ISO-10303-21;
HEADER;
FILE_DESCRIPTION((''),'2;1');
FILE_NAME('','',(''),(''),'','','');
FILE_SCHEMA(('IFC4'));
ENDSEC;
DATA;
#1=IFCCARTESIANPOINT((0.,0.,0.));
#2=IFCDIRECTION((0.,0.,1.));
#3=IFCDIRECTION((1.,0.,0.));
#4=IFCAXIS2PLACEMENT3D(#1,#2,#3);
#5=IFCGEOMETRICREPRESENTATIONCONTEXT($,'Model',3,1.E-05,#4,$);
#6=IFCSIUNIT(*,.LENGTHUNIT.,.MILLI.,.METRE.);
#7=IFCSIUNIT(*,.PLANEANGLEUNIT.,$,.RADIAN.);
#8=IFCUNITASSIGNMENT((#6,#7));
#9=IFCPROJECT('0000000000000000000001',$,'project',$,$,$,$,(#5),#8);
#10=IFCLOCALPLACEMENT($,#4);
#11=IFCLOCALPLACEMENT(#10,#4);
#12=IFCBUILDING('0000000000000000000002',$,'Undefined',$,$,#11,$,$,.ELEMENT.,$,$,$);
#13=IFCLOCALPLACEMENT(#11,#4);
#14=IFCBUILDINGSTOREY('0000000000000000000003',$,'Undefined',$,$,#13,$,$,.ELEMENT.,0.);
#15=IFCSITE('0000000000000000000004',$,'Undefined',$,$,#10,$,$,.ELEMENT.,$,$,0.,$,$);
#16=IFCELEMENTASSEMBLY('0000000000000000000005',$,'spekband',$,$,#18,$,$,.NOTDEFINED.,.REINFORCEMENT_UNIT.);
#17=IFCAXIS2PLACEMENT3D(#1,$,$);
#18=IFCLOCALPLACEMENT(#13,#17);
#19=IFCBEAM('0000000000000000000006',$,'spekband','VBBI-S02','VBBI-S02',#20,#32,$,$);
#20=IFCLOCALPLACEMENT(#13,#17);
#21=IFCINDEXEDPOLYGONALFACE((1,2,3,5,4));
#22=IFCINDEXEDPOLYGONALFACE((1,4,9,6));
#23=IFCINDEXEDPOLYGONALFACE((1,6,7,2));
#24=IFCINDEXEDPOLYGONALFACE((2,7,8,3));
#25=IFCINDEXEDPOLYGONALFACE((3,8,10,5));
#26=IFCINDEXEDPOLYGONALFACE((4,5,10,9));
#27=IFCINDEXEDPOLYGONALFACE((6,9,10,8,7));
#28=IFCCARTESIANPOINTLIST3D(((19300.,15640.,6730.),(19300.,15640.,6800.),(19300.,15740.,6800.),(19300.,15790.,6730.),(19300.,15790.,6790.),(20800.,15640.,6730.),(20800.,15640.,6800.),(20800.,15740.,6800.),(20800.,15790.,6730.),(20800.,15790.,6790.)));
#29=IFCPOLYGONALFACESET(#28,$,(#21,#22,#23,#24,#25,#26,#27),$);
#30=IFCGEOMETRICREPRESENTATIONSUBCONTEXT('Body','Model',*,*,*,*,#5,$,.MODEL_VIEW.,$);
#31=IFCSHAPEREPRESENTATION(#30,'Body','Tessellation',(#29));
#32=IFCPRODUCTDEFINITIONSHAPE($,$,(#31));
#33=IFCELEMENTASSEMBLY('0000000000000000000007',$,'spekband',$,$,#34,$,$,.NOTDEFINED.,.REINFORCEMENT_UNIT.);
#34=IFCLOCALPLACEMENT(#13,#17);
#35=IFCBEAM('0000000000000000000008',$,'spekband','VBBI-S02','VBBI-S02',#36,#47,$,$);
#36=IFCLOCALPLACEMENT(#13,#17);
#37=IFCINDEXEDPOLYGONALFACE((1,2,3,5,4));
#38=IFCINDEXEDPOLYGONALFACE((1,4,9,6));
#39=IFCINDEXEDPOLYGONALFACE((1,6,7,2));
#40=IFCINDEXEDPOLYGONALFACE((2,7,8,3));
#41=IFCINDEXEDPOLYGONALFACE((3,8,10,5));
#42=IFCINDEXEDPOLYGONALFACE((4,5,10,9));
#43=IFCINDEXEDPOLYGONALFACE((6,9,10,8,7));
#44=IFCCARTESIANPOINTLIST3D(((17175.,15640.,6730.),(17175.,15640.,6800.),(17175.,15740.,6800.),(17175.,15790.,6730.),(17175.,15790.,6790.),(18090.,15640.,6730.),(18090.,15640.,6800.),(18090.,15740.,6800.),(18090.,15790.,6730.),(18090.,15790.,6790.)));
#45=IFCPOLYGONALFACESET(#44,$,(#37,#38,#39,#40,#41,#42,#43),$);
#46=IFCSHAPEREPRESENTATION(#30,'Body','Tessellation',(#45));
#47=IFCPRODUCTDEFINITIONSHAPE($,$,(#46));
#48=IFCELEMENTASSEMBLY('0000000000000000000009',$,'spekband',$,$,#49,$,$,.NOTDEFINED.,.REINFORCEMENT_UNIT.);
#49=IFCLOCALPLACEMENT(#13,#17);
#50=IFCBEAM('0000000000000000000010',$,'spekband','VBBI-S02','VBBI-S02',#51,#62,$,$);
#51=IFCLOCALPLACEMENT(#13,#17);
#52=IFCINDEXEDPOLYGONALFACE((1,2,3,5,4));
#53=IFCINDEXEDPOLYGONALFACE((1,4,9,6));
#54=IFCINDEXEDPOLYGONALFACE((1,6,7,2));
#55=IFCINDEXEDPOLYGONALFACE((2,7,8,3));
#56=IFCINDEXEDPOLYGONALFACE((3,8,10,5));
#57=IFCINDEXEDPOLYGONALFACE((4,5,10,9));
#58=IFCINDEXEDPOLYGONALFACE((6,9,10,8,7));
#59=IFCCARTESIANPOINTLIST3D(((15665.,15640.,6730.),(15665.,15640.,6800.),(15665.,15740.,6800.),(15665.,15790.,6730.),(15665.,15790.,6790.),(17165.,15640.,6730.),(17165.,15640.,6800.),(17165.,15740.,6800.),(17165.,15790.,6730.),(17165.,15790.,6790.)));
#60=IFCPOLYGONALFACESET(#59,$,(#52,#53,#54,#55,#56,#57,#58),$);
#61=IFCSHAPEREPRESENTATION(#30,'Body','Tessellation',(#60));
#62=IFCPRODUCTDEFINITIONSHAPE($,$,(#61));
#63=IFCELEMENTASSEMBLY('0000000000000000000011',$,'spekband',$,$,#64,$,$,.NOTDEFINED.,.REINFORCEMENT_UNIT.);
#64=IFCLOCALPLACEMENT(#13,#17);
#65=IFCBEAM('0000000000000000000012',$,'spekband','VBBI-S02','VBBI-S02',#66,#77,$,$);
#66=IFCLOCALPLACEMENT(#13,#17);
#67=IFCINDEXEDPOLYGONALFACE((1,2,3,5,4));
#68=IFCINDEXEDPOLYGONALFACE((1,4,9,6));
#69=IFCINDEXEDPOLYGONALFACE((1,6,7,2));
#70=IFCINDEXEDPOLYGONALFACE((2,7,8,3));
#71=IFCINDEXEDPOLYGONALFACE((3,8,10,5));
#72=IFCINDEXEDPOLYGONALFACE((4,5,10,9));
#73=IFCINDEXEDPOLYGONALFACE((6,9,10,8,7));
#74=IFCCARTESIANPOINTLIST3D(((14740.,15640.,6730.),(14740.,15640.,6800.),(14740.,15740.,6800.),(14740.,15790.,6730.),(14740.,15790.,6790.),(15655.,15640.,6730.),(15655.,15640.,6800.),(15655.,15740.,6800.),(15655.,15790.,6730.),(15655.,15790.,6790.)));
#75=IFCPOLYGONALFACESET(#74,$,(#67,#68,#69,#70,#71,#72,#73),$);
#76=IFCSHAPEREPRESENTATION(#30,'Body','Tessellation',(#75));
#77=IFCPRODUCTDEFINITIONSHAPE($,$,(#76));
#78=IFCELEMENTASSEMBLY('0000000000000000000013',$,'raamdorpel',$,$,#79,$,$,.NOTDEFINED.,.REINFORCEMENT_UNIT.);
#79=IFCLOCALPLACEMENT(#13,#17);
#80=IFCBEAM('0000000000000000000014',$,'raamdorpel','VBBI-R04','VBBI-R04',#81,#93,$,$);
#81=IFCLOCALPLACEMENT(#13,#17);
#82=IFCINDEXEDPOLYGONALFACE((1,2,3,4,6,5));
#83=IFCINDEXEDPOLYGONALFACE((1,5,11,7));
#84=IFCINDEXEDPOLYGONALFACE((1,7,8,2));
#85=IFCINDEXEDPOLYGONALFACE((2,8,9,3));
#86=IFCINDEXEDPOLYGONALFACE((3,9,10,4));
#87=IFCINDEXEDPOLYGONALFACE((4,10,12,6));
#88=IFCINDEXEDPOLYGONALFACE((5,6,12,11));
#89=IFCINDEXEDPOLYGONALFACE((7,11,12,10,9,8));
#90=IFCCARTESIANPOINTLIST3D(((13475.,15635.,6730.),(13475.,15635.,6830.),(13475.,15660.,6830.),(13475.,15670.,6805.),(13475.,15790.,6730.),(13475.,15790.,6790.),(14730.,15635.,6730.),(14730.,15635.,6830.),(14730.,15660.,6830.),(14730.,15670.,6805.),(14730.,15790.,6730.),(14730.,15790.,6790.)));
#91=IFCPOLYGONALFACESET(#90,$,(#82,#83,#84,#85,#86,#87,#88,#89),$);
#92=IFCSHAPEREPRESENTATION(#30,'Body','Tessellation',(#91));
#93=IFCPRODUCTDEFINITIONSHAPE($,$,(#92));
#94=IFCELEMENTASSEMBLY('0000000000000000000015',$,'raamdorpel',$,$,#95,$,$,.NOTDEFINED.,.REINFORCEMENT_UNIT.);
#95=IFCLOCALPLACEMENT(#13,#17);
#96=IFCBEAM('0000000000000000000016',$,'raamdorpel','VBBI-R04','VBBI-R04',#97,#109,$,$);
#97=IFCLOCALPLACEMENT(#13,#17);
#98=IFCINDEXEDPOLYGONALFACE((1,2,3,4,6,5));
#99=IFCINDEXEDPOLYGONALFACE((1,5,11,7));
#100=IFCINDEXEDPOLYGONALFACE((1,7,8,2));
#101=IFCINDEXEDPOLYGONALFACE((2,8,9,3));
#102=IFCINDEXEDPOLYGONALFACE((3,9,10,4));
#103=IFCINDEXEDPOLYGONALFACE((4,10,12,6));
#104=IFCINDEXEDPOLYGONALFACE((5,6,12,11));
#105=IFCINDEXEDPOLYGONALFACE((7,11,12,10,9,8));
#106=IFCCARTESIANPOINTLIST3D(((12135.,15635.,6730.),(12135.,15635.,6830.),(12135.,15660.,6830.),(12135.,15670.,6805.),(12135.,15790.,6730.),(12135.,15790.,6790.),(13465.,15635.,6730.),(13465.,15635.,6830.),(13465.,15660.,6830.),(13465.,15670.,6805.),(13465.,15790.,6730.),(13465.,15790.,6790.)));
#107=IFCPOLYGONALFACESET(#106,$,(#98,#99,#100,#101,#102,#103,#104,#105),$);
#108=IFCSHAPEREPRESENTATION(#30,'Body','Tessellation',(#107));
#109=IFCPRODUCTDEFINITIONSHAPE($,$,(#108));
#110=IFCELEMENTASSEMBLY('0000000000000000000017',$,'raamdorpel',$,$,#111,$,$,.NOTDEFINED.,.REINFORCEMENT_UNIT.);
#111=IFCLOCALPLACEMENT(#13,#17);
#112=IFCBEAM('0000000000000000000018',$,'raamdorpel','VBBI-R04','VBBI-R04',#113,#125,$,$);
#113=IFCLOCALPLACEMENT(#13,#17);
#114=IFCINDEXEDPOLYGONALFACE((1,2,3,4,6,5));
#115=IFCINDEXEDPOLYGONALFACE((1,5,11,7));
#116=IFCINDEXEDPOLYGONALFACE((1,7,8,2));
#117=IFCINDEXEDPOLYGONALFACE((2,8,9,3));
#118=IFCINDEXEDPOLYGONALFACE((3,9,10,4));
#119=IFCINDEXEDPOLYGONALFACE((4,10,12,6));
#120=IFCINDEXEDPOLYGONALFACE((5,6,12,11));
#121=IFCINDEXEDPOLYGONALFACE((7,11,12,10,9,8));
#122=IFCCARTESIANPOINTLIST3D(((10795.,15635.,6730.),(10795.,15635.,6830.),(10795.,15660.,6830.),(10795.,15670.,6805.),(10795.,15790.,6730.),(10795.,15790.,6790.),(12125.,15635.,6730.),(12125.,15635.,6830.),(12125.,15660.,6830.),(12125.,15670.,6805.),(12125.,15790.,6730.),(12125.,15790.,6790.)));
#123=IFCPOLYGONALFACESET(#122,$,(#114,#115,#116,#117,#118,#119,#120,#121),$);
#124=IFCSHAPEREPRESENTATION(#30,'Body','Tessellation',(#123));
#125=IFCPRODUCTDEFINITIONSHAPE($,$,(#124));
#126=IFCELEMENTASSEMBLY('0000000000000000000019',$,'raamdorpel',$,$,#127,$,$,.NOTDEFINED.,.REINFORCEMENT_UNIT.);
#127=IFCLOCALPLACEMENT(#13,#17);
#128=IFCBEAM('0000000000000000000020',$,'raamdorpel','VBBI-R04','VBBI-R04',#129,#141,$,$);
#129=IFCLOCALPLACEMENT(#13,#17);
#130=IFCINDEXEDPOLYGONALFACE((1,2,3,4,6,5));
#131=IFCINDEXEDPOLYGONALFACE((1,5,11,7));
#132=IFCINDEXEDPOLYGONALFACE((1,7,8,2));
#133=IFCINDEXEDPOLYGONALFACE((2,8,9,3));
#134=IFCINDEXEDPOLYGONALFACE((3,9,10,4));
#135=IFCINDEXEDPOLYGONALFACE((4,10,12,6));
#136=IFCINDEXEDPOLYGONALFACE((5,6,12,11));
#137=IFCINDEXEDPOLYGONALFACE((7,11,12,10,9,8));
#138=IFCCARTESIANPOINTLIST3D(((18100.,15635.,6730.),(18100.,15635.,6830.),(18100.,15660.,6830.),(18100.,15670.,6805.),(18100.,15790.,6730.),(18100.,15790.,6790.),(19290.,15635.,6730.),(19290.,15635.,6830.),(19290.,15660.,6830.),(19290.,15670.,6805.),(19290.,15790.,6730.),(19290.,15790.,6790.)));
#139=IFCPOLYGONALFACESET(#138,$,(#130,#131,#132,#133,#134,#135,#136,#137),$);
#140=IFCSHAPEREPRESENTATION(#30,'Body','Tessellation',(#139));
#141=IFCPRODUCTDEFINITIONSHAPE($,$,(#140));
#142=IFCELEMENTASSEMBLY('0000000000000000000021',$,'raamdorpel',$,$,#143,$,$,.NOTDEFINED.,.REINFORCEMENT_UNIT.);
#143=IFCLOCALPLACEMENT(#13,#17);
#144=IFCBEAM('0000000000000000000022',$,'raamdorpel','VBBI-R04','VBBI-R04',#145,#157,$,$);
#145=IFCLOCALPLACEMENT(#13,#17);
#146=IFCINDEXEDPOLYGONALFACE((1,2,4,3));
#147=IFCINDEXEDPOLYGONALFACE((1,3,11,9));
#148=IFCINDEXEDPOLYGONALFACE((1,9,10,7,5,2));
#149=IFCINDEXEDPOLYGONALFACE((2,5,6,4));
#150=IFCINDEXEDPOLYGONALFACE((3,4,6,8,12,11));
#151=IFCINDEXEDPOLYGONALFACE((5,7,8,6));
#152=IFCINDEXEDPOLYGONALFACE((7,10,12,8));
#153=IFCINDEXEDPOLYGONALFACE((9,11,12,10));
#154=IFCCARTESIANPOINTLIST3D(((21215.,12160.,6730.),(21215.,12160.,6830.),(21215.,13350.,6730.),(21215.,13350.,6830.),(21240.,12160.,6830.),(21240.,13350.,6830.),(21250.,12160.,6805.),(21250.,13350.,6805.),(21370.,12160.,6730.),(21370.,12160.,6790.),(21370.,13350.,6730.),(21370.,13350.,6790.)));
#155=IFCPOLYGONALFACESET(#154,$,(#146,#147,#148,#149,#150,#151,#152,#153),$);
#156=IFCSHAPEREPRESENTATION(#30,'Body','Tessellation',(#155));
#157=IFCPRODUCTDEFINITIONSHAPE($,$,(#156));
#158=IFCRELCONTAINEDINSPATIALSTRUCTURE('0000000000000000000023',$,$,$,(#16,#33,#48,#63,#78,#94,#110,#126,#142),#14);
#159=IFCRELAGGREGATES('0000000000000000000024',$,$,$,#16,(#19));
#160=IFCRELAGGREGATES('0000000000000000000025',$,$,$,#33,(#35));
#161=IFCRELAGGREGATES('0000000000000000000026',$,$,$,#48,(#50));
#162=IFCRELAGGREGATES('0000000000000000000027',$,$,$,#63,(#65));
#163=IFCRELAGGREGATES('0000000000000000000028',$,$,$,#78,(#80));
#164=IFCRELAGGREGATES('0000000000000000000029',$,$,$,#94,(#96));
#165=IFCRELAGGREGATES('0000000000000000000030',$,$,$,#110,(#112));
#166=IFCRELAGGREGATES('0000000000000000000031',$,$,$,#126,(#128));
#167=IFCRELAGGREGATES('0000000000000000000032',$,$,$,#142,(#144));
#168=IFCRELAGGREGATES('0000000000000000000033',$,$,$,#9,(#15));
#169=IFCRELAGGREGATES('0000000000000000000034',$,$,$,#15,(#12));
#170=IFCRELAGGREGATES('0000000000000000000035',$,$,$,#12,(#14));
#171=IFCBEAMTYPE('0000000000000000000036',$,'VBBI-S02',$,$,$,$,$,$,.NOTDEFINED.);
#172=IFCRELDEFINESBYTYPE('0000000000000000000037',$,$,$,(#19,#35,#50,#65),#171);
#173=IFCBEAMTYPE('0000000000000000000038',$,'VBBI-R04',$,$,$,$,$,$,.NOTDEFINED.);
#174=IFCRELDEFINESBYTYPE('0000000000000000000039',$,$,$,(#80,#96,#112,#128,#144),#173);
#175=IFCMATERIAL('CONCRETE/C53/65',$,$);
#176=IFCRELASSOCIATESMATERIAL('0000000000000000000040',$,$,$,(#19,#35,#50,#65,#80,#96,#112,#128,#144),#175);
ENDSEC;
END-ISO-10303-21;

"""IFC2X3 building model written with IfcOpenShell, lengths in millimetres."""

from ifc_helpers import new_model, si_unit, frame, origin_with_axes, place, context, subcontext, project, spatial, polyline, outline, extrude, material, type_object, element, aggregate, save


model = new_model("IFC2X3")

# Units and contexts
model_context = context("Model", 3, precision=1e-05, world=origin_with_axes())
body_context = subcontext(model_context, "Body", "Model", "MODEL_VIEW")
ifc_project = project(units=[si_unit("LENGTHUNIT", "METRE", prefix="MILLI"), si_unit("PLANEANGLEUNIT", "RADIAN")], contexts=[model_context])

# Site, building, storey
site_placement = place(None, origin_with_axes())
site = spatial("IfcSite", under=ifc_project, at=site_placement, Name="Undefined", CompositionType="ELEMENT", RefElevation=0.0)
building_placement = place(site_placement, origin_with_axes())
building = spatial("IfcBuilding", under=site, at=building_placement, Name="Undefined", CompositionType="ELEMENT")
storey_placement = place(building_placement, origin_with_axes())
storey = spatial("IfcBuildingStorey", under=building, at=storey_placement, Name="Undefined", CompositionType="ELEMENT", Elevation=0.0)

# Element assemblies, beams
ifc_material = material(Name="CONCRETE/C53/65")
beam_type_1 = type_object("IfcBeamType", Name="VBBI-S02", PredefinedType="NOTDEFINED")
assembly_1_placement = place(storey_placement, origin_with_axes())
assembly_1 = element("IfcElementAssembly", 1, at=assembly_1_placement, inside=storey, Name="spekband", AssemblyPlace="NOTDEFINED", PredefinedType="REINFORCEMENT_UNIT")
beam_1_placement = place(assembly_1_placement, frame((20800.0, 15715.0, 6765.0), z_axis=(0.0, 1.0, 0.0), x_axis=(-1.0, 0.0, 0.0)))
beam_1 = element("IfcBeam", 2, at=beam_1_placement, type_object=beam_type_1, material=ifc_material, Name="spekband", Description="VBBI-S02", ObjectType="VBBI-S02", context=body_context, shape_type="SweptSolid", body=[
    extrude(outline(polyline([(35.0, -75.0), (-35.0, -75.0), (-35.0, 25.0), (-25.0, 75.0), (35.0, 75.0), (35.0, -75.0)])), frame((1500.0, 0.0, 0.0), z_axis=(-1.0, 0.0, 0.0), x_axis=(0.0, -1.0, 0.0)), (0.0, 0.0, 1.0), 1500.0),
])
aggregate(assembly_1, [beam_1])
assembly_2_placement = place(storey_placement, origin_with_axes())
assembly_2 = element("IfcElementAssembly", 3, at=assembly_2_placement, inside=storey, Name="spekband", AssemblyPlace="NOTDEFINED", PredefinedType="REINFORCEMENT_UNIT")
beam_2_placement = place(assembly_2_placement, frame((18090.0, 15715.0, 6765.0), z_axis=(0.0, 1.0, 0.0), x_axis=(-1.0, 0.0, 0.0)))
beam_2 = element("IfcBeam", 4, at=beam_2_placement, type_object=beam_type_1, material=ifc_material, Name="spekband", Description="VBBI-S02", ObjectType="VBBI-S02", context=body_context, shape_type="SweptSolid", body=[
    extrude(outline(polyline([(35.0, -75.0), (-35.0, -75.0), (-35.0, 25.0), (-25.0, 75.0), (35.0, 75.0), (35.0, -75.0)])), frame((915.0, 0.0, 0.0), z_axis=(-1.0, 0.0, 0.0), x_axis=(0.0, -1.0, 0.0)), (0.0, 0.0, 1.0), 915.0),
])
aggregate(assembly_2, [beam_2])
assembly_3_placement = place(storey_placement, origin_with_axes())
assembly_3 = element("IfcElementAssembly", 5, at=assembly_3_placement, inside=storey, Name="spekband", AssemblyPlace="NOTDEFINED", PredefinedType="REINFORCEMENT_UNIT")
beam_3_placement = place(assembly_3_placement, frame((17165.0, 15715.0, 6765.0), z_axis=(0.0, 1.0, 0.0), x_axis=(-1.0, 0.0, 0.0)))
beam_3 = element("IfcBeam", 6, at=beam_3_placement, type_object=beam_type_1, material=ifc_material, Name="spekband", Description="VBBI-S02", ObjectType="VBBI-S02", context=body_context, shape_type="SweptSolid", body=[
    extrude(outline(polyline([(35.0, -75.0), (-35.0, -75.0), (-35.0, 25.0), (-25.0, 75.0), (35.0, 75.0), (35.0, -75.0)])), frame((1500.0, 0.0, 0.0), z_axis=(-1.0, 0.0, 0.0), x_axis=(0.0, -1.0, 0.0)), (0.0, 0.0, 1.0), 1500.0),
])
aggregate(assembly_3, [beam_3])
assembly_4_placement = place(storey_placement, origin_with_axes())
assembly_4 = element("IfcElementAssembly", 7, at=assembly_4_placement, inside=storey, Name="spekband", AssemblyPlace="NOTDEFINED", PredefinedType="REINFORCEMENT_UNIT")
beam_4_placement = place(assembly_4_placement, frame((15655.0, 15715.0, 6765.0), z_axis=(0.0, 1.0, 0.0), x_axis=(-1.0, 0.0, 0.0)))
beam_4 = element("IfcBeam", 8, at=beam_4_placement, type_object=beam_type_1, material=ifc_material, Name="spekband", Description="VBBI-S02", ObjectType="VBBI-S02", context=body_context, shape_type="SweptSolid", body=[
    extrude(outline(polyline([(35.0, -75.0), (-35.0, -75.0), (-35.0, 25.0), (-25.0, 75.0), (35.0, 75.0), (35.0, -75.0)])), frame((915.0, 0.0, 0.0), z_axis=(-1.0, 0.0, 0.0), x_axis=(0.0, -1.0, 0.0)), (0.0, 0.0, 1.0), 915.0),
])
aggregate(assembly_4, [beam_4])
assembly_5_placement = place(storey_placement, origin_with_axes())
assembly_5 = element("IfcElementAssembly", 9, at=assembly_5_placement, inside=storey, Name="raamdorpel", AssemblyPlace="NOTDEFINED", PredefinedType="REINFORCEMENT_UNIT")
beam_type_2 = type_object("IfcBeamType", Name="VBBI-R04", PredefinedType="NOTDEFINED")
beam_5_placement = place(assembly_5_placement, frame((14730.0, 15712.5, 6780.0), z_axis=(0.0, 1.0, 0.0), x_axis=(-1.0, 0.0, 0.0)))
beam_5 = element("IfcBeam", 10, at=beam_5_placement, type_object=beam_type_2, material=ifc_material, Name="raamdorpel", Description="VBBI-R04", ObjectType="VBBI-R04", context=body_context, shape_type="SweptSolid", body=[
    extrude(outline(polyline([(50.0, -77.5), (-50.0, -77.5), (-50.0, -52.5), (-25.0, -42.5), (-10.0, 77.5), (50.0, 77.5), (50.0, -77.5)])), frame((1255.0, 0.0, 0.0), z_axis=(-1.0, 0.0, 0.0), x_axis=(0.0, -1.0, 0.0)), (0.0, 0.0, 1.0), 1255.0),
])
aggregate(assembly_5, [beam_5])
assembly_6_placement = place(storey_placement, origin_with_axes())
assembly_6 = element("IfcElementAssembly", 11, at=assembly_6_placement, inside=storey, Name="raamdorpel", AssemblyPlace="NOTDEFINED", PredefinedType="REINFORCEMENT_UNIT")
beam_6_placement = place(assembly_6_placement, frame((13465.0, 15712.5, 6780.0), z_axis=(0.0, 1.0, 0.0), x_axis=(-1.0, 0.0, 0.0)))
beam_6 = element("IfcBeam", 12, at=beam_6_placement, type_object=beam_type_2, material=ifc_material, Name="raamdorpel", Description="VBBI-R04", ObjectType="VBBI-R04", context=body_context, shape_type="SweptSolid", body=[
    extrude(outline(polyline([(50.0, -77.5), (-50.0, -77.5), (-50.0, -52.5), (-25.0, -42.5), (-10.0, 77.5), (50.0, 77.5), (50.0, -77.5)])), frame((1330.0, 0.0, 0.0), z_axis=(-1.0, 0.0, 0.0), x_axis=(0.0, -1.0, 0.0)), (0.0, 0.0, 1.0), 1330.0),
])
aggregate(assembly_6, [beam_6])
assembly_7_placement = place(storey_placement, origin_with_axes())
assembly_7 = element("IfcElementAssembly", 13, at=assembly_7_placement, inside=storey, Name="raamdorpel", AssemblyPlace="NOTDEFINED", PredefinedType="REINFORCEMENT_UNIT")
beam_7_placement = place(assembly_7_placement, frame((12125.0, 15712.5, 6780.0), z_axis=(0.0, 1.0, 0.0), x_axis=(-1.0, 0.0, 0.0)))
beam_7 = element("IfcBeam", 14, at=beam_7_placement, type_object=beam_type_2, material=ifc_material, Name="raamdorpel", Description="VBBI-R04", ObjectType="VBBI-R04", context=body_context, shape_type="SweptSolid", body=[
    extrude(outline(polyline([(50.0, -77.5), (-50.0, -77.5), (-50.0, -52.5), (-25.0, -42.5), (-10.0, 77.5), (50.0, 77.5), (50.0, -77.5)])), frame((1330.0, 0.0, 0.0), z_axis=(-1.0, 0.0, 0.0), x_axis=(0.0, -1.0, 0.0)), (0.0, 0.0, 1.0), 1330.0),
])
aggregate(assembly_7, [beam_7])
assembly_8_placement = place(storey_placement, origin_with_axes())
assembly_8 = element("IfcElementAssembly", 15, at=assembly_8_placement, inside=storey, Name="raamdorpel", AssemblyPlace="NOTDEFINED", PredefinedType="REINFORCEMENT_UNIT")
beam_8_placement = place(assembly_8_placement, frame((19290.0, 15712.5, 6780.0), z_axis=(0.0, 1.0, 0.0), x_axis=(-1.0, 0.0, 0.0)))
beam_8 = element("IfcBeam", 16, at=beam_8_placement, type_object=beam_type_2, material=ifc_material, Name="raamdorpel", Description="VBBI-R04", ObjectType="VBBI-R04", context=body_context, shape_type="SweptSolid", body=[
    extrude(outline(polyline([(50.0, -77.5), (-50.0, -77.5), (-50.0, -52.5), (-25.0, -42.5), (-10.0, 77.5), (50.0, 77.5), (50.0, -77.5)])), frame((1190.0, 0.0, 0.0), z_axis=(-1.0, 0.0, 0.0), x_axis=(0.0, -1.0, 0.0)), (0.0, 0.0, 1.0), 1190.0),
])
aggregate(assembly_8, [beam_8])
assembly_9_placement = place(storey_placement, origin_with_axes())
assembly_9 = element("IfcElementAssembly", 17, at=assembly_9_placement, inside=storey, Name="raamdorpel", AssemblyPlace="NOTDEFINED", PredefinedType="REINFORCEMENT_UNIT")
beam_9_placement = place(assembly_9_placement, frame((21292.5, 12160.0, 6780.0), z_axis=(1.0, 0.0, 0.0), x_axis=(0.0, 1.0, 0.0)))
beam_9 = element("IfcBeam", 18, at=beam_9_placement, type_object=beam_type_2, material=ifc_material, Name="raamdorpel", Description="VBBI-R04", ObjectType="VBBI-R04", context=body_context, shape_type="SweptSolid", body=[
    extrude(outline(polyline([(50.0, -77.5), (-50.0, -77.5), (-50.0, -52.5), (-25.0, -42.5), (-10.0, 77.5), (50.0, 77.5), (50.0, -77.5)])), frame((1190.0, 0.0, 0.0), z_axis=(-1.0, 0.0, 0.0), x_axis=(0.0, -1.0, 0.0)), (0.0, 0.0, 1.0), 1190.0),
])
aggregate(assembly_9, [beam_9])

save(model, "model.ifc")
